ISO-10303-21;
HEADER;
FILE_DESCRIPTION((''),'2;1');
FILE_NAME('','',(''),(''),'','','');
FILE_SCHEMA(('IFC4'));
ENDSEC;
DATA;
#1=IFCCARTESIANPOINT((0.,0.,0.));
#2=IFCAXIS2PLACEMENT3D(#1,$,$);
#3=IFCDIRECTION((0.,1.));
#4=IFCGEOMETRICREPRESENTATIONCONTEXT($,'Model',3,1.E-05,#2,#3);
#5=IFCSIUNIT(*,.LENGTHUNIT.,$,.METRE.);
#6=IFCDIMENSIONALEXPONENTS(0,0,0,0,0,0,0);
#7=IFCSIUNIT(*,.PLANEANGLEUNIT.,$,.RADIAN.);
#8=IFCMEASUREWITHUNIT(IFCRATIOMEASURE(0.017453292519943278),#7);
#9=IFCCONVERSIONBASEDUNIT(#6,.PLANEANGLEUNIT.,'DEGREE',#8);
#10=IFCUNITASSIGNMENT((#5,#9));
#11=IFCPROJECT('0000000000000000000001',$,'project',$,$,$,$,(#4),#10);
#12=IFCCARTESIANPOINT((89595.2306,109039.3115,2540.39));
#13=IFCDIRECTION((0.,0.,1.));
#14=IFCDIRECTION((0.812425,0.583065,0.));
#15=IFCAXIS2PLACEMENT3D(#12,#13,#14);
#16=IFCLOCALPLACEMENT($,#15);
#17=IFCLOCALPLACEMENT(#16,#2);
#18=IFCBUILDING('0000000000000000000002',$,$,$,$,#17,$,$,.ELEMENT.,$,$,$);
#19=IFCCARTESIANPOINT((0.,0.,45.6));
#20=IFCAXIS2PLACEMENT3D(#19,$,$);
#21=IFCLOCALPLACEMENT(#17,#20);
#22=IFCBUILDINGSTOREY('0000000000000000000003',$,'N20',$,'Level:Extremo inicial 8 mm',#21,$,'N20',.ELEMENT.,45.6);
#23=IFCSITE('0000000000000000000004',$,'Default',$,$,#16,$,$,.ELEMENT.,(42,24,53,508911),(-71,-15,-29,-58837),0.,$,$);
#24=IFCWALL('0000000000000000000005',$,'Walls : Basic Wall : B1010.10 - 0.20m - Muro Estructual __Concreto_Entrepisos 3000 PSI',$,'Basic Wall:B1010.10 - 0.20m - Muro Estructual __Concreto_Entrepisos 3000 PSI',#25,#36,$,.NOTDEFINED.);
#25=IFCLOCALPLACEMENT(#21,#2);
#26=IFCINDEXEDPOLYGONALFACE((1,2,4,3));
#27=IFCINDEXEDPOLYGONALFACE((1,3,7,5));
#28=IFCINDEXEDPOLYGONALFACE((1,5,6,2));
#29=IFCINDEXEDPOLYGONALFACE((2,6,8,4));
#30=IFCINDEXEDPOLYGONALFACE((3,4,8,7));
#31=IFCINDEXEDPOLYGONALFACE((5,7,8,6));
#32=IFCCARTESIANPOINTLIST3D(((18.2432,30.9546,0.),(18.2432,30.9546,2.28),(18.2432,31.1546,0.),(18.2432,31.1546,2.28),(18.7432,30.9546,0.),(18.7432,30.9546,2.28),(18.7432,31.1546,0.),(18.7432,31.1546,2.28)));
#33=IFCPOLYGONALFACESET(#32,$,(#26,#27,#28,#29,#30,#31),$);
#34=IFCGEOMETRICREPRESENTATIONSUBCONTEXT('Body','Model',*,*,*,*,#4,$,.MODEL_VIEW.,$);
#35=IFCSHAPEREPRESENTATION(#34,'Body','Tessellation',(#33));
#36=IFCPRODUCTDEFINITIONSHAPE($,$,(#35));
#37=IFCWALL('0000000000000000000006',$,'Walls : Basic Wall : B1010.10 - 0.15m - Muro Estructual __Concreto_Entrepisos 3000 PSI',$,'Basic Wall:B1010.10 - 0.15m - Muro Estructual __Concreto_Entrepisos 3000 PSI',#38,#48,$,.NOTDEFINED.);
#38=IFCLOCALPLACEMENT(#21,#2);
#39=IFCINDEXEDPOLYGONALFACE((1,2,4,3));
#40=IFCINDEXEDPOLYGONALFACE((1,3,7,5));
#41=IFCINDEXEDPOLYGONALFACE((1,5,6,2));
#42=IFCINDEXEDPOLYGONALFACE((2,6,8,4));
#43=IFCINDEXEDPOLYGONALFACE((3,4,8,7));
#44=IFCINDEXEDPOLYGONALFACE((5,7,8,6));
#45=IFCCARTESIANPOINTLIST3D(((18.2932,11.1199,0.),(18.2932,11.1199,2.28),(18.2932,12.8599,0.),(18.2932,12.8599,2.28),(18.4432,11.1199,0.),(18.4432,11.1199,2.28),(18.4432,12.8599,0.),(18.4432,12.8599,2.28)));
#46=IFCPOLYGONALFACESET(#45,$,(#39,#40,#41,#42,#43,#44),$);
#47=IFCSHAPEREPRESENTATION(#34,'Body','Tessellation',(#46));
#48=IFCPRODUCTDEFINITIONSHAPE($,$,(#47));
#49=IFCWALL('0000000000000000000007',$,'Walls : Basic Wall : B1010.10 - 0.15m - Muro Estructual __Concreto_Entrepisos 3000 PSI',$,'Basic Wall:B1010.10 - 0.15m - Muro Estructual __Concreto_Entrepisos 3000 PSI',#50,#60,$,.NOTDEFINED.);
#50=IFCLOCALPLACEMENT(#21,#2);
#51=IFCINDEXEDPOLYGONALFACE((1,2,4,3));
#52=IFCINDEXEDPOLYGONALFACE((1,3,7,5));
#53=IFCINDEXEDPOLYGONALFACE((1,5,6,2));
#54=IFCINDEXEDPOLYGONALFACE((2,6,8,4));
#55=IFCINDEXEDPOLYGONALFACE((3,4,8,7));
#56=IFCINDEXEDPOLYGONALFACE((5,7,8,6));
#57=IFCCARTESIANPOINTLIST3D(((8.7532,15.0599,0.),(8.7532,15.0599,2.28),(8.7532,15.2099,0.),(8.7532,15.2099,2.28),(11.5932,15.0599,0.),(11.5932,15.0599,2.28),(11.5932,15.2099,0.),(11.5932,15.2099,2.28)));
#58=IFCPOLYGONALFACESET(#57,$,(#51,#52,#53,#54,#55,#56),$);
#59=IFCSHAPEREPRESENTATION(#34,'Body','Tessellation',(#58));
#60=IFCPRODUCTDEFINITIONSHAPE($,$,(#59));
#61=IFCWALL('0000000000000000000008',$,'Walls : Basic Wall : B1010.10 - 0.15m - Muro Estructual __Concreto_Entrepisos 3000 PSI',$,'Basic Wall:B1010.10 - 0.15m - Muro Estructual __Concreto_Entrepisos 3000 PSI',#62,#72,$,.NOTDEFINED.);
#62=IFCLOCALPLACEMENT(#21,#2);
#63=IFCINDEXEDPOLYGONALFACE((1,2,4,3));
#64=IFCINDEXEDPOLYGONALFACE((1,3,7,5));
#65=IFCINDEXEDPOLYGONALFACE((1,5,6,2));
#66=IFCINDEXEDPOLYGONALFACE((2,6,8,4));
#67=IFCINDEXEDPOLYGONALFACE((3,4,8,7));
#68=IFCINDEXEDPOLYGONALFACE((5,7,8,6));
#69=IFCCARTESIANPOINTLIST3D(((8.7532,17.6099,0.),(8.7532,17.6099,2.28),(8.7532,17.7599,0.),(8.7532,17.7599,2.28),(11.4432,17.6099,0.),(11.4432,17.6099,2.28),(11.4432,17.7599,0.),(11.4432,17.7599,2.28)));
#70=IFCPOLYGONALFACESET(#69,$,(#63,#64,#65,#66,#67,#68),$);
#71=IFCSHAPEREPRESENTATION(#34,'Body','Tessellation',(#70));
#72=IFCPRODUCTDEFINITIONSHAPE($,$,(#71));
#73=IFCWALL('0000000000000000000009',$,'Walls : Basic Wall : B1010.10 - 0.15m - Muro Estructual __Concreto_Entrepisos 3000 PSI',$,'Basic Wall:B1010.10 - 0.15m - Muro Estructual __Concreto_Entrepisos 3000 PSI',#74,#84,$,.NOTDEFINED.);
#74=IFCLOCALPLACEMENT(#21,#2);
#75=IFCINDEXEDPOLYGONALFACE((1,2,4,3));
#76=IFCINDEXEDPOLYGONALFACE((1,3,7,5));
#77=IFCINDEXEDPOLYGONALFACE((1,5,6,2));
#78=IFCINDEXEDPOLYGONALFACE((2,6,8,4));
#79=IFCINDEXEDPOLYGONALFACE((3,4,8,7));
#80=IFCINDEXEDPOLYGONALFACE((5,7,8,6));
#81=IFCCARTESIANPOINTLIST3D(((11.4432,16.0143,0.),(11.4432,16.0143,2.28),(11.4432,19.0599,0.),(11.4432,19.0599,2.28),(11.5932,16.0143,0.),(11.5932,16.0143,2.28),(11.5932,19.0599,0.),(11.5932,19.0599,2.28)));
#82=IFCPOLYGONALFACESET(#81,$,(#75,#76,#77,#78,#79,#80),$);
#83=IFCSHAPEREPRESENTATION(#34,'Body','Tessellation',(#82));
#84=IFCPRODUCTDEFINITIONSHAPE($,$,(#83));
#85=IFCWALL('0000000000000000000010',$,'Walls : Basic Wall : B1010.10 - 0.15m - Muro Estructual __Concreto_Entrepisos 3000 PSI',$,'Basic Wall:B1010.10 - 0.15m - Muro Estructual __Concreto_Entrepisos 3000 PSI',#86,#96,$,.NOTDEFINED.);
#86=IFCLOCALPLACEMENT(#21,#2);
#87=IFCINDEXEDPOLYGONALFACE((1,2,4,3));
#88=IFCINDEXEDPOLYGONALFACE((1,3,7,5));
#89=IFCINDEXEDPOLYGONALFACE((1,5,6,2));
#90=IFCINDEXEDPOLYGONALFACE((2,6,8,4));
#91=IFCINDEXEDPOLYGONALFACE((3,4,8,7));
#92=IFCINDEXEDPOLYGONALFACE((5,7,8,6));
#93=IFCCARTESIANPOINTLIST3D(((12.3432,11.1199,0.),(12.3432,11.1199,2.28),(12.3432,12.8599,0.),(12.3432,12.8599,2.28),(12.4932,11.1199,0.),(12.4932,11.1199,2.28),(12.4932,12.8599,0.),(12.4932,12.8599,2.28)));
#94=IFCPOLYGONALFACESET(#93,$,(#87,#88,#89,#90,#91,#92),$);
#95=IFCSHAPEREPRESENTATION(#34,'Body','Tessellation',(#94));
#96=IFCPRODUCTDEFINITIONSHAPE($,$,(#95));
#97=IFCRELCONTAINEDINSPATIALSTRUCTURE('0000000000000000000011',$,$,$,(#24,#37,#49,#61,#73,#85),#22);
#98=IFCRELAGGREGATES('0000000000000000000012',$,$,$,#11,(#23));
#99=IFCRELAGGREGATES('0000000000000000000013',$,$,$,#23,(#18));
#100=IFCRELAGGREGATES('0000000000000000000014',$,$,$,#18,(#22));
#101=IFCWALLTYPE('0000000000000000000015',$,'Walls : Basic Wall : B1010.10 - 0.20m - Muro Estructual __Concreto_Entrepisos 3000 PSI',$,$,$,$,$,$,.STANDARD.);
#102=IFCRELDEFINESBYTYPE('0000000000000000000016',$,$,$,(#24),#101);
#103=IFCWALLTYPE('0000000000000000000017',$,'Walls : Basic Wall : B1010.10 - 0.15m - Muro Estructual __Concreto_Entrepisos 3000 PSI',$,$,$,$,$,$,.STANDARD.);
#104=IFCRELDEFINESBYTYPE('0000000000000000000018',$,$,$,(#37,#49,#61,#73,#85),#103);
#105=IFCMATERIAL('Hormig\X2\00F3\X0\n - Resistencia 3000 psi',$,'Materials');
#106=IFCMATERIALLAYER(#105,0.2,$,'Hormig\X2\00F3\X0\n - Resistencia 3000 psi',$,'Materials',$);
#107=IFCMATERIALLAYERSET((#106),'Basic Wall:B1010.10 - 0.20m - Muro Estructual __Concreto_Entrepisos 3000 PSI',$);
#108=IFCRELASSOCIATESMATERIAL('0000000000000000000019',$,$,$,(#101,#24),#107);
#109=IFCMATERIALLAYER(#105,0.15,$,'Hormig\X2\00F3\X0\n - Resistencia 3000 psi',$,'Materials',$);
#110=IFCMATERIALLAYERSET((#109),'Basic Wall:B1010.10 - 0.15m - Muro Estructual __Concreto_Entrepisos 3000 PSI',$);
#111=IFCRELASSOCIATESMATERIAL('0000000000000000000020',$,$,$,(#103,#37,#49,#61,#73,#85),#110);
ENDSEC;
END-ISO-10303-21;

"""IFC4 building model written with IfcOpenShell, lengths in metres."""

from ifc_helpers import new_model, entity, si_unit, converted_unit, direction, frame, frame_2d, origin, place, context, subcontext, project, spatial, rectangle, extrude, material, layer, layer_set, layer_usage, type_object, element, save


model = new_model("IFC4")

# Units and contexts
model_context = context("Model", 3, precision=1e-05, world=origin(), true_north=direction((0.0, 1.0)))
body_context = subcontext(model_context, "Body", "Model", "MODEL_VIEW")
ifc_project = project(units=[si_unit("LENGTHUNIT", "METRE"), converted_unit("PLANEANGLEUNIT", "DEGREE", entity("IfcRatioMeasure", 0.017453292519943278), si_unit("PLANEANGLEUNIT", "RADIAN"), dimensions=[0, 0, 0, 0, 0, 0, 0])], contexts=[model_context])

# Site, building, storey
site_placement = place(None, frame((89595.2306, 109039.3115, 2540.39), z_axis=(0.0, 0.0, 1.0), x_axis=(0.812425, 0.583065, 0.0)))
site = spatial("IfcSite", under=ifc_project, at=site_placement, Name="Default", CompositionType="ELEMENT", RefLatitude=(42, 24, 53, 508911), RefLongitude=(-71, -15, -29, -58837), RefElevation=0.0)
building_placement = place(site_placement, origin())
building = spatial("IfcBuilding", under=site, at=building_placement, CompositionType="ELEMENT")
storey_placement = place(building_placement, frame((0.0, 0.0, 45.6)))
storey = spatial("IfcBuildingStorey", under=building, at=storey_placement, Name="N20", ObjectType="Level:Extremo inicial 8 mm", LongName="N20", CompositionType="ELEMENT", Elevation=45.6)

# Walls
ifc_material = material(Name="Hormigón - Resistencia 3000 psi", Category="Materials")
ifc_layer_1 = layer(ifc_material, 0.2, Name="Hormigón - Resistencia 3000 psi", Category="Materials")
ifc_layer_set_1 = layer_set([ifc_layer_1], Name="Basic Wall:B1010.10 - 0.20m - Muro Estructual __Concreto_Entrepisos 3000 PSI")
wall_type_1 = type_object("IfcWallType", Name="Walls : Basic Wall : B1010.10 - 0.20m - Muro Estructual __Concreto_Entrepisos 3000 PSI", PredefinedType="STANDARD", material=ifc_layer_set_1)
ifc_layer_usage_1 = layer_usage(ifc_layer_set_1, "AXIS2", "NEGATIVE", 0.1)
wall_1_placement = place(storey_placement, frame((18.7432, 31.0546, 0.0), z_axis=(0.0, 0.0, 1.0), x_axis=(-1.0, 0.0, 0.0)))
element("IfcWall", 1, at=wall_1_placement, inside=storey, type_object=wall_type_1, material=ifc_layer_usage_1, Name="Walls : Basic Wall : B1010.10 - 0.20m - Muro Estructual __Concreto_Entrepisos 3000 PSI", ObjectType="Basic Wall:B1010.10 - 0.20m - Muro Estructual __Concreto_Entrepisos 3000 PSI", PredefinedType="NOTDEFINED", context=body_context, shape_type="SweptSolid", body=[
    extrude(rectangle(XDim=0.5, YDim=0.2, at=frame_2d((0.25, 0.0), x_axis=(-1.0, 0.0))), origin(), (0.0, 0.0, 1.0), 2.28),
])
ifc_layer_2 = layer(ifc_material, 0.15, Name="Hormigón - Resistencia 3000 psi", Category="Materials")
ifc_layer_set_2 = layer_set([ifc_layer_2], Name="Basic Wall:B1010.10 - 0.15m - Muro Estructual __Concreto_Entrepisos 3000 PSI")
ifc_layer_usage_2 = layer_usage(ifc_layer_set_2, "AXIS2", "NEGATIVE", 0.075)
wall_type_2 = type_object("IfcWallType", Name="Walls : Basic Wall : B1010.10 - 0.15m - Muro Estructual __Concreto_Entrepisos 3000 PSI", PredefinedType="STANDARD", material=ifc_layer_set_2)
wall_2_placement = place(storey_placement, frame((18.3682, 11.1199, 0.0), z_axis=(0.0, 0.0, 1.0), x_axis=(0.0, 1.0, 0.0)))
element("IfcWall", 2, at=wall_2_placement, inside=storey, type_object=wall_type_2, material=ifc_layer_usage_2, Name="Walls : Basic Wall : B1010.10 - 0.15m - Muro Estructual __Concreto_Entrepisos 3000 PSI", ObjectType="Basic Wall:B1010.10 - 0.15m - Muro Estructual __Concreto_Entrepisos 3000 PSI", PredefinedType="NOTDEFINED", context=body_context, shape_type="SweptSolid", body=[
    extrude(rectangle(XDim=1.74, YDim=0.15, at=frame_2d((0.87, 0.0), x_axis=(-1.0, 0.0))), origin(), (0.0, 0.0, 1.0), 2.28),
])
ifc_layer_usage_3 = layer_usage(ifc_layer_set_2, "AXIS2", "POSITIVE", -0.075)
wall_3_placement = place(storey_placement, frame((8.7532, 15.1349, 0.0)))
element("IfcWall", 3, at=wall_3_placement, inside=storey, type_object=wall_type_2, material=ifc_layer_usage_3, Name="Walls : Basic Wall : B1010.10 - 0.15m - Muro Estructual __Concreto_Entrepisos 3000 PSI", ObjectType="Basic Wall:B1010.10 - 0.15m - Muro Estructual __Concreto_Entrepisos 3000 PSI", PredefinedType="NOTDEFINED", context=body_context, shape_type="SweptSolid", body=[
    extrude(rectangle(XDim=2.84, YDim=0.15, at=frame_2d((1.42, 0.0), x_axis=(-1.0, 0.0))), origin(), (0.0, 0.0, 1.0), 2.28),
])
ifc_layer_usage_4 = layer_usage(ifc_layer_set_2, "AXIS2", "POSITIVE", -0.075)
wall_4_placement = place(storey_placement, frame((8.7532, 17.6849, 0.0)))
element("IfcWall", 4, at=wall_4_placement, inside=storey, type_object=wall_type_2, material=ifc_layer_usage_4, Name="Walls : Basic Wall : B1010.10 - 0.15m - Muro Estructual __Concreto_Entrepisos 3000 PSI", ObjectType="Basic Wall:B1010.10 - 0.15m - Muro Estructual __Concreto_Entrepisos 3000 PSI", PredefinedType="NOTDEFINED", context=body_context, shape_type="SweptSolid", body=[
    extrude(rectangle(XDim=2.69, YDim=0.15, at=frame_2d((1.345, 0.0), x_axis=(-1.0, 0.0))), origin(), (0.0, 0.0, 1.0), 2.28),
])
ifc_layer_usage_5 = layer_usage(ifc_layer_set_2, "AXIS2", "POSITIVE", -0.075)
wall_5_placement = place(storey_placement, frame((11.5182, 16.0143, 0.0), z_axis=(0.0, 0.0, 1.0), x_axis=(0.0, 1.0, 0.0)))
element("IfcWall", 5, at=wall_5_placement, inside=storey, type_object=wall_type_2, material=ifc_layer_usage_5, Name="Walls : Basic Wall : B1010.10 - 0.15m - Muro Estructual __Concreto_Entrepisos 3000 PSI", ObjectType="Basic Wall:B1010.10 - 0.15m - Muro Estructual __Concreto_Entrepisos 3000 PSI", PredefinedType="NOTDEFINED", context=body_context, shape_type="SweptSolid", body=[
    extrude(rectangle(XDim=3.0455, YDim=0.15, at=frame_2d((1.5228, 0.0), x_axis=(-1.0, 0.0))), origin(), (0.0, 0.0, 1.0), 2.28),
])
ifc_layer_usage_6 = layer_usage(ifc_layer_set_2, "AXIS2", "POSITIVE", -0.075)
wall_6_placement = place(storey_placement, frame((12.4182, 11.1199, 0.0), z_axis=(0.0, 0.0, 1.0), x_axis=(0.0, 1.0, 0.0)))
element("IfcWall", 6, at=wall_6_placement, inside=storey, type_object=wall_type_2, material=ifc_layer_usage_6, Name="Walls : Basic Wall : B1010.10 - 0.15m - Muro Estructual __Concreto_Entrepisos 3000 PSI", ObjectType="Basic Wall:B1010.10 - 0.15m - Muro Estructual __Concreto_Entrepisos 3000 PSI", PredefinedType="NOTDEFINED", context=body_context, shape_type="SweptSolid", body=[
    extrude(rectangle(XDim=1.74, YDim=0.15, at=frame_2d((0.87, 0.0), x_axis=(-1.0, 0.0))), origin(), (0.0, 0.0, 1.0), 2.28),
])

save(model, "model.ifc")
